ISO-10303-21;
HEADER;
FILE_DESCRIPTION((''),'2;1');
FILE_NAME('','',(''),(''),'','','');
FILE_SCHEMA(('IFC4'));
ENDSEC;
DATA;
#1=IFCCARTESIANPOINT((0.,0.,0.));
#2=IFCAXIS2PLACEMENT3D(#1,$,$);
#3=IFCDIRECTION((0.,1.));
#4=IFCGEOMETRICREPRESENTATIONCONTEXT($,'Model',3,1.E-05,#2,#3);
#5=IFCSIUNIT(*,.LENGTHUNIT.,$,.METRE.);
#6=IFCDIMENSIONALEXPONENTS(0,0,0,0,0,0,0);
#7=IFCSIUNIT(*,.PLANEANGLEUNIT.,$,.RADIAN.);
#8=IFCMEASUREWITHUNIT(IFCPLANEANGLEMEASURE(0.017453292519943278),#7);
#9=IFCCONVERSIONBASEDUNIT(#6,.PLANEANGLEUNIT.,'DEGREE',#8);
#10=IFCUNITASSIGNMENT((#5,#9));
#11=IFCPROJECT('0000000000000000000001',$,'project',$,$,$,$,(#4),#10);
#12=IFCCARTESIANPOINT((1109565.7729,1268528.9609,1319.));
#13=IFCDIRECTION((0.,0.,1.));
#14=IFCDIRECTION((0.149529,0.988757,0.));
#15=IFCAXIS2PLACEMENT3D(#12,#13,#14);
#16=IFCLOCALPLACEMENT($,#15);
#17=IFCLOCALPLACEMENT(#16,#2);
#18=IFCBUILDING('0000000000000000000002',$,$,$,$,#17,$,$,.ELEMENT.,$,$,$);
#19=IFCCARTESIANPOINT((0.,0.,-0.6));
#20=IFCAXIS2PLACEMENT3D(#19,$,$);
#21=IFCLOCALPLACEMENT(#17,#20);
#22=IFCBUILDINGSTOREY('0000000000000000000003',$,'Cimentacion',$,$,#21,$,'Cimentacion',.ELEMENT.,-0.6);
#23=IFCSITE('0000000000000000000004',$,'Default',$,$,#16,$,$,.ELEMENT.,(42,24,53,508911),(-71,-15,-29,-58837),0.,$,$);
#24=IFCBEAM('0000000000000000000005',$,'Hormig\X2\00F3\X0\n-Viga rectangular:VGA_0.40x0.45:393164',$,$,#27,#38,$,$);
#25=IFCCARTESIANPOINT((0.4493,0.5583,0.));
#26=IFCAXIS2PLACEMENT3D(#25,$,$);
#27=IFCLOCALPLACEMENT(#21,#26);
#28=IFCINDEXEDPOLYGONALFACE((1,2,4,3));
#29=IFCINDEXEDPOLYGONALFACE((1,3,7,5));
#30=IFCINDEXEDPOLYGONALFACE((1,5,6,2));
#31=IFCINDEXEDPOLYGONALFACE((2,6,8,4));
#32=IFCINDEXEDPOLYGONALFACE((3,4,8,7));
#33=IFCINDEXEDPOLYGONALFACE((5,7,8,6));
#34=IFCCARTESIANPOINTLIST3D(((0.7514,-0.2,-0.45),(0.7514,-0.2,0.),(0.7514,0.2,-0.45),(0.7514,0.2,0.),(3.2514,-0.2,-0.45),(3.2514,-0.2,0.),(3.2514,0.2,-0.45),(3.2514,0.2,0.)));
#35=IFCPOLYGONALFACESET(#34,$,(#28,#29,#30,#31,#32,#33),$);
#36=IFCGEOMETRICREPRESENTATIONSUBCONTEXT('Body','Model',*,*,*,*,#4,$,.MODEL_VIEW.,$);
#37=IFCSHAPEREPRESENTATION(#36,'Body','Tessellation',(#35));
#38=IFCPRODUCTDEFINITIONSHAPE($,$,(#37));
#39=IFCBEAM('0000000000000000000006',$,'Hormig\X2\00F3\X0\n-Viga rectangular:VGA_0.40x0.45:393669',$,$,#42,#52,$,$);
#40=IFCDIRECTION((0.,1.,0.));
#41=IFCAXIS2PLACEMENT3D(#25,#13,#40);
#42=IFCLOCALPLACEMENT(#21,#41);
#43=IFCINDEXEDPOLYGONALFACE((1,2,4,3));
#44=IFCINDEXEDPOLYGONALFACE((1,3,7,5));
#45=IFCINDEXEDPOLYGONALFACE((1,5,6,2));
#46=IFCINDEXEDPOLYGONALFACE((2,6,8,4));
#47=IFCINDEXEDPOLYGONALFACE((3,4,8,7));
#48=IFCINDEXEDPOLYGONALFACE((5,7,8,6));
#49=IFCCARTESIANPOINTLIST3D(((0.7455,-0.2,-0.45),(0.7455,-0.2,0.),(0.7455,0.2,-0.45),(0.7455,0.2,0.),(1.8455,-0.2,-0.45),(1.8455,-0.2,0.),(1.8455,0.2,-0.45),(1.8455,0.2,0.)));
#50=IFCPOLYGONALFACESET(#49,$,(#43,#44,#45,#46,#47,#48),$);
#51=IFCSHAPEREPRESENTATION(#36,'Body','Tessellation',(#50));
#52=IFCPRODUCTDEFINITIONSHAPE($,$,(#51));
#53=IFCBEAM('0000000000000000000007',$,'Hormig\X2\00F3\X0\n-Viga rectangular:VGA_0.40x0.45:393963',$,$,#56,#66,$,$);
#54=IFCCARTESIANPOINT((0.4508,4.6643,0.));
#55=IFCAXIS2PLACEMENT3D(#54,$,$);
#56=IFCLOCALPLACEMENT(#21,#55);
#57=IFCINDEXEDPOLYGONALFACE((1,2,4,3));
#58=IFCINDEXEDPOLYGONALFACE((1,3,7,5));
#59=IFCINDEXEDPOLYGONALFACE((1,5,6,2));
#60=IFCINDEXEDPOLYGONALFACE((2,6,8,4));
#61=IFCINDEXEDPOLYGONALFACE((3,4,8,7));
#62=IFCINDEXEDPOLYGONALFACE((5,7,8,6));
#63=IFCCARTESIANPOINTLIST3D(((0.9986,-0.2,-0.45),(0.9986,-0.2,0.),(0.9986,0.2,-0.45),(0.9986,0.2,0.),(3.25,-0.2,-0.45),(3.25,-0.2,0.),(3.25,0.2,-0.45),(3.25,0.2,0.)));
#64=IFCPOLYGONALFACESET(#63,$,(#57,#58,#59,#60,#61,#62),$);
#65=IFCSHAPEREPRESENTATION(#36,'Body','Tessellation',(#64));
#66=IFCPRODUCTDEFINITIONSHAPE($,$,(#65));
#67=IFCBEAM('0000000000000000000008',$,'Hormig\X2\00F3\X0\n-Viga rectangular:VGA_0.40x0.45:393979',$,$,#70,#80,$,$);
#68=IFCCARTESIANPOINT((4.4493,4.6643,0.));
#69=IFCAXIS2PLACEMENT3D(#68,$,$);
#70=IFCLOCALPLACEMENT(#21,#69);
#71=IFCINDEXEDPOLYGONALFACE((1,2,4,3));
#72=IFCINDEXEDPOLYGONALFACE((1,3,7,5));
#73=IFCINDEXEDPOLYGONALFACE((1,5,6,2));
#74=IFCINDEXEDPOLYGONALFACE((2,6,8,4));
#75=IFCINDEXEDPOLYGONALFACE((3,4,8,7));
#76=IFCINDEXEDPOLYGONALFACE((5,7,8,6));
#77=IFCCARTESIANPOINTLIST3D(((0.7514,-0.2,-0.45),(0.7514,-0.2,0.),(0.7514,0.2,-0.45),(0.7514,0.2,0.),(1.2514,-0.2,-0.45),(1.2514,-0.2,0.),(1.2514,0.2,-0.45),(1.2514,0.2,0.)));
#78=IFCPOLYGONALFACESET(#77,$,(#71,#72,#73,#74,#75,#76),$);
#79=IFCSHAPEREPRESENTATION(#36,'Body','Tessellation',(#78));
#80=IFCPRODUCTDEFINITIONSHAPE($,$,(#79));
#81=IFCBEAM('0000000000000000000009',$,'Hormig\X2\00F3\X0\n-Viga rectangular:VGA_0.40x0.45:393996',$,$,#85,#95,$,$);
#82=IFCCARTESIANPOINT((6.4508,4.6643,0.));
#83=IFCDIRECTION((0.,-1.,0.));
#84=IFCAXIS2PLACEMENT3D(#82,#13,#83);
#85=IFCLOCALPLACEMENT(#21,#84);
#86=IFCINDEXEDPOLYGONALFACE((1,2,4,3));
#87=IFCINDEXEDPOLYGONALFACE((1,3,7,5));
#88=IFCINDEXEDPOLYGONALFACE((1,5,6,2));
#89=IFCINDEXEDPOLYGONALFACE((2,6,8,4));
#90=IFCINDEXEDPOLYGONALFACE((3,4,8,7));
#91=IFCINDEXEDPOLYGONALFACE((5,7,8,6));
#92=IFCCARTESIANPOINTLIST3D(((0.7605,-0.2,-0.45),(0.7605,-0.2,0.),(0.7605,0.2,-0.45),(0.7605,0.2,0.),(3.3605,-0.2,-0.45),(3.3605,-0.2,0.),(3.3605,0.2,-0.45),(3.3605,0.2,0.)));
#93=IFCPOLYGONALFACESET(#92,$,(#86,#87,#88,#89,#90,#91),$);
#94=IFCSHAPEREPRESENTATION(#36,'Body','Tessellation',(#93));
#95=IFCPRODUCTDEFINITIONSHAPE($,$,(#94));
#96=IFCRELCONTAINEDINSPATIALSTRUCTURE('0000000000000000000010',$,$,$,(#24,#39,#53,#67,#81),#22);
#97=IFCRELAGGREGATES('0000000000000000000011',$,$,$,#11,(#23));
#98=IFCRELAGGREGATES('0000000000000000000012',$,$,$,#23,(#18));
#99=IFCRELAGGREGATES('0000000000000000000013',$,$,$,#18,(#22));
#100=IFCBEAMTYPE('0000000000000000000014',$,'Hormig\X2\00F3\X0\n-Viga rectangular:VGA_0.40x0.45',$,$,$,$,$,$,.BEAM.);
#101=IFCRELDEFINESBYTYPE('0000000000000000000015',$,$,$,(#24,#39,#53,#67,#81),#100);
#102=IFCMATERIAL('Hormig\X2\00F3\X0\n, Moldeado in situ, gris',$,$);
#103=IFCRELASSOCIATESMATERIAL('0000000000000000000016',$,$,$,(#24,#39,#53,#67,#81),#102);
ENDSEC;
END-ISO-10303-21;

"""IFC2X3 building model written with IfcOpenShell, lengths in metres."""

from ifc_helpers import new_model, entity, si_unit, converted_unit, direction, frame, frame_2d, origin, place, context, subcontext, project, spatial, rectangle, extrude, material, type_object, element, save


model = new_model("IFC2X3")

# Units and contexts
model_context = context("Model", 3, precision=1e-05, world=origin(), true_north=direction((0.0, 1.0)))
body_context = subcontext(model_context, "Body", "Model", "MODEL_VIEW")
ifc_project = project(units=[si_unit("LENGTHUNIT", "METRE"), converted_unit("PLANEANGLEUNIT", "DEGREE", entity("IfcPlaneAngleMeasure", 0.017453292519943278), si_unit("PLANEANGLEUNIT", "RADIAN"), dimensions=[0, 0, 0, 0, 0, 0, 0])], contexts=[model_context])

# Site, building, storey
site_placement = place(None, frame((1109565.7729, 1268528.9609, 1319.0), z_axis=(0.0, 0.0, 1.0), x_axis=(0.149529, 0.988757, 0.0)))
site = spatial("IfcSite", under=ifc_project, at=site_placement, Name="Default", CompositionType="ELEMENT", RefLatitude=(42, 24, 53, 508911), RefLongitude=(-71, -15, -29, -58837), RefElevation=0.0)
building_placement = place(site_placement, origin())
building = spatial("IfcBuilding", under=site, at=building_placement, CompositionType="ELEMENT")
storey_placement = place(building_placement, frame((0.0, 0.0, -0.6)))
storey = spatial("IfcBuildingStorey", under=building, at=storey_placement, Name="Cimentacion", LongName="Cimentacion", CompositionType="ELEMENT", Elevation=-0.6)

# Beams
ifc_material_1 = material(Name="Hormigón, Moldeado in situ, gris")
beam_type = type_object("IfcBeamType", Name="Hormigón-Viga rectangular:VGA_0.40x0.45", PredefinedType="BEAM")
beam_1_placement = place(storey_placement, frame((0.4493, 0.5583, 0.0)))
element("IfcBeam", 1, at=beam_1_placement, inside=storey, type_object=beam_type, material=ifc_material_1, Name="Hormigón-Viga rectangular:VGA_0.40x0.45:393164", context=body_context, shape_type="SweptSolid", body=[
    extrude(rectangle(XDim=0.45, YDim=0.4, at=frame_2d((0.0, 0.0), x_axis=(1.0, 0.0))), frame((0.7514, 0.0, -0.225), z_axis=(1.0, 0.0, 0.0), x_axis=(0.0, 0.0, -1.0)), (0.0, 0.0, 1.0), 2.5),
])
beam_2_placement = place(storey_placement, frame((0.4493, 0.5583, 0.0), z_axis=(0.0, 0.0, 1.0), x_axis=(0.0, 1.0, 0.0)))
element("IfcBeam", 2, at=beam_2_placement, inside=storey, type_object=beam_type, material=ifc_material_1, Name="Hormigón-Viga rectangular:VGA_0.40x0.45:393669", context=body_context, shape_type="SweptSolid", body=[
    extrude(rectangle(XDim=0.45, YDim=0.4, at=frame_2d((0.0, 0.0), x_axis=(1.0, 0.0))), frame((0.7455, 0.0, -0.225), z_axis=(1.0, 0.0, 0.0), x_axis=(0.0, 0.0, -1.0)), (0.0, 0.0, 1.0), 1.1),
])
beam_3_placement = place(storey_placement, frame((0.4508, 4.6643, 0.0)))
element("IfcBeam", 3, at=beam_3_placement, inside=storey, type_object=beam_type, material=ifc_material_1, Name="Hormigón-Viga rectangular:VGA_0.40x0.45:393963", context=body_context, shape_type="SweptSolid", body=[
    extrude(rectangle(XDim=0.45, YDim=0.4, at=frame_2d((0.0, 0.0), x_axis=(1.0, 0.0))), frame((0.9986, 0.0, -0.225), z_axis=(1.0, 0.0, 0.0), x_axis=(0.0, 0.0, -1.0)), (0.0, 0.0, 1.0), 2.2514),
])
beam_4_placement = place(storey_placement, frame((4.4493, 4.6643, 0.0)))
element("IfcBeam", 4, at=beam_4_placement, inside=storey, type_object=beam_type, material=ifc_material_1, Name="Hormigón-Viga rectangular:VGA_0.40x0.45:393979", context=body_context, shape_type="SweptSolid", body=[
    extrude(rectangle(XDim=0.45, YDim=0.4, at=frame_2d((0.0, 0.0), x_axis=(1.0, 0.0))), frame((0.7514, 0.0, -0.225), z_axis=(1.0, 0.0, 0.0), x_axis=(0.0, 0.0, -1.0)), (0.0, 0.0, 1.0), 0.5),
])
beam_5_placement = place(storey_placement, frame((6.4508, 4.6643, 0.0), z_axis=(0.0, 0.0, 1.0), x_axis=(0.0, -1.0, 0.0)))
element("IfcBeam", 5, at=beam_5_placement, inside=storey, type_object=beam_type, material=ifc_material_1, Name="Hormigón-Viga rectangular:VGA_0.40x0.45:393996", context=body_context, shape_type="SweptSolid", body=[
    extrude(rectangle(XDim=0.45, YDim=0.4, at=frame_2d((0.0, 0.0), x_axis=(1.0, 0.0))), frame((0.7605, 0.0, -0.225), z_axis=(1.0, 0.0, 0.0), x_axis=(0.0, 0.0, -1.0)), (0.0, 0.0, 1.0), 2.6),
])

save(model, "model.ifc")
